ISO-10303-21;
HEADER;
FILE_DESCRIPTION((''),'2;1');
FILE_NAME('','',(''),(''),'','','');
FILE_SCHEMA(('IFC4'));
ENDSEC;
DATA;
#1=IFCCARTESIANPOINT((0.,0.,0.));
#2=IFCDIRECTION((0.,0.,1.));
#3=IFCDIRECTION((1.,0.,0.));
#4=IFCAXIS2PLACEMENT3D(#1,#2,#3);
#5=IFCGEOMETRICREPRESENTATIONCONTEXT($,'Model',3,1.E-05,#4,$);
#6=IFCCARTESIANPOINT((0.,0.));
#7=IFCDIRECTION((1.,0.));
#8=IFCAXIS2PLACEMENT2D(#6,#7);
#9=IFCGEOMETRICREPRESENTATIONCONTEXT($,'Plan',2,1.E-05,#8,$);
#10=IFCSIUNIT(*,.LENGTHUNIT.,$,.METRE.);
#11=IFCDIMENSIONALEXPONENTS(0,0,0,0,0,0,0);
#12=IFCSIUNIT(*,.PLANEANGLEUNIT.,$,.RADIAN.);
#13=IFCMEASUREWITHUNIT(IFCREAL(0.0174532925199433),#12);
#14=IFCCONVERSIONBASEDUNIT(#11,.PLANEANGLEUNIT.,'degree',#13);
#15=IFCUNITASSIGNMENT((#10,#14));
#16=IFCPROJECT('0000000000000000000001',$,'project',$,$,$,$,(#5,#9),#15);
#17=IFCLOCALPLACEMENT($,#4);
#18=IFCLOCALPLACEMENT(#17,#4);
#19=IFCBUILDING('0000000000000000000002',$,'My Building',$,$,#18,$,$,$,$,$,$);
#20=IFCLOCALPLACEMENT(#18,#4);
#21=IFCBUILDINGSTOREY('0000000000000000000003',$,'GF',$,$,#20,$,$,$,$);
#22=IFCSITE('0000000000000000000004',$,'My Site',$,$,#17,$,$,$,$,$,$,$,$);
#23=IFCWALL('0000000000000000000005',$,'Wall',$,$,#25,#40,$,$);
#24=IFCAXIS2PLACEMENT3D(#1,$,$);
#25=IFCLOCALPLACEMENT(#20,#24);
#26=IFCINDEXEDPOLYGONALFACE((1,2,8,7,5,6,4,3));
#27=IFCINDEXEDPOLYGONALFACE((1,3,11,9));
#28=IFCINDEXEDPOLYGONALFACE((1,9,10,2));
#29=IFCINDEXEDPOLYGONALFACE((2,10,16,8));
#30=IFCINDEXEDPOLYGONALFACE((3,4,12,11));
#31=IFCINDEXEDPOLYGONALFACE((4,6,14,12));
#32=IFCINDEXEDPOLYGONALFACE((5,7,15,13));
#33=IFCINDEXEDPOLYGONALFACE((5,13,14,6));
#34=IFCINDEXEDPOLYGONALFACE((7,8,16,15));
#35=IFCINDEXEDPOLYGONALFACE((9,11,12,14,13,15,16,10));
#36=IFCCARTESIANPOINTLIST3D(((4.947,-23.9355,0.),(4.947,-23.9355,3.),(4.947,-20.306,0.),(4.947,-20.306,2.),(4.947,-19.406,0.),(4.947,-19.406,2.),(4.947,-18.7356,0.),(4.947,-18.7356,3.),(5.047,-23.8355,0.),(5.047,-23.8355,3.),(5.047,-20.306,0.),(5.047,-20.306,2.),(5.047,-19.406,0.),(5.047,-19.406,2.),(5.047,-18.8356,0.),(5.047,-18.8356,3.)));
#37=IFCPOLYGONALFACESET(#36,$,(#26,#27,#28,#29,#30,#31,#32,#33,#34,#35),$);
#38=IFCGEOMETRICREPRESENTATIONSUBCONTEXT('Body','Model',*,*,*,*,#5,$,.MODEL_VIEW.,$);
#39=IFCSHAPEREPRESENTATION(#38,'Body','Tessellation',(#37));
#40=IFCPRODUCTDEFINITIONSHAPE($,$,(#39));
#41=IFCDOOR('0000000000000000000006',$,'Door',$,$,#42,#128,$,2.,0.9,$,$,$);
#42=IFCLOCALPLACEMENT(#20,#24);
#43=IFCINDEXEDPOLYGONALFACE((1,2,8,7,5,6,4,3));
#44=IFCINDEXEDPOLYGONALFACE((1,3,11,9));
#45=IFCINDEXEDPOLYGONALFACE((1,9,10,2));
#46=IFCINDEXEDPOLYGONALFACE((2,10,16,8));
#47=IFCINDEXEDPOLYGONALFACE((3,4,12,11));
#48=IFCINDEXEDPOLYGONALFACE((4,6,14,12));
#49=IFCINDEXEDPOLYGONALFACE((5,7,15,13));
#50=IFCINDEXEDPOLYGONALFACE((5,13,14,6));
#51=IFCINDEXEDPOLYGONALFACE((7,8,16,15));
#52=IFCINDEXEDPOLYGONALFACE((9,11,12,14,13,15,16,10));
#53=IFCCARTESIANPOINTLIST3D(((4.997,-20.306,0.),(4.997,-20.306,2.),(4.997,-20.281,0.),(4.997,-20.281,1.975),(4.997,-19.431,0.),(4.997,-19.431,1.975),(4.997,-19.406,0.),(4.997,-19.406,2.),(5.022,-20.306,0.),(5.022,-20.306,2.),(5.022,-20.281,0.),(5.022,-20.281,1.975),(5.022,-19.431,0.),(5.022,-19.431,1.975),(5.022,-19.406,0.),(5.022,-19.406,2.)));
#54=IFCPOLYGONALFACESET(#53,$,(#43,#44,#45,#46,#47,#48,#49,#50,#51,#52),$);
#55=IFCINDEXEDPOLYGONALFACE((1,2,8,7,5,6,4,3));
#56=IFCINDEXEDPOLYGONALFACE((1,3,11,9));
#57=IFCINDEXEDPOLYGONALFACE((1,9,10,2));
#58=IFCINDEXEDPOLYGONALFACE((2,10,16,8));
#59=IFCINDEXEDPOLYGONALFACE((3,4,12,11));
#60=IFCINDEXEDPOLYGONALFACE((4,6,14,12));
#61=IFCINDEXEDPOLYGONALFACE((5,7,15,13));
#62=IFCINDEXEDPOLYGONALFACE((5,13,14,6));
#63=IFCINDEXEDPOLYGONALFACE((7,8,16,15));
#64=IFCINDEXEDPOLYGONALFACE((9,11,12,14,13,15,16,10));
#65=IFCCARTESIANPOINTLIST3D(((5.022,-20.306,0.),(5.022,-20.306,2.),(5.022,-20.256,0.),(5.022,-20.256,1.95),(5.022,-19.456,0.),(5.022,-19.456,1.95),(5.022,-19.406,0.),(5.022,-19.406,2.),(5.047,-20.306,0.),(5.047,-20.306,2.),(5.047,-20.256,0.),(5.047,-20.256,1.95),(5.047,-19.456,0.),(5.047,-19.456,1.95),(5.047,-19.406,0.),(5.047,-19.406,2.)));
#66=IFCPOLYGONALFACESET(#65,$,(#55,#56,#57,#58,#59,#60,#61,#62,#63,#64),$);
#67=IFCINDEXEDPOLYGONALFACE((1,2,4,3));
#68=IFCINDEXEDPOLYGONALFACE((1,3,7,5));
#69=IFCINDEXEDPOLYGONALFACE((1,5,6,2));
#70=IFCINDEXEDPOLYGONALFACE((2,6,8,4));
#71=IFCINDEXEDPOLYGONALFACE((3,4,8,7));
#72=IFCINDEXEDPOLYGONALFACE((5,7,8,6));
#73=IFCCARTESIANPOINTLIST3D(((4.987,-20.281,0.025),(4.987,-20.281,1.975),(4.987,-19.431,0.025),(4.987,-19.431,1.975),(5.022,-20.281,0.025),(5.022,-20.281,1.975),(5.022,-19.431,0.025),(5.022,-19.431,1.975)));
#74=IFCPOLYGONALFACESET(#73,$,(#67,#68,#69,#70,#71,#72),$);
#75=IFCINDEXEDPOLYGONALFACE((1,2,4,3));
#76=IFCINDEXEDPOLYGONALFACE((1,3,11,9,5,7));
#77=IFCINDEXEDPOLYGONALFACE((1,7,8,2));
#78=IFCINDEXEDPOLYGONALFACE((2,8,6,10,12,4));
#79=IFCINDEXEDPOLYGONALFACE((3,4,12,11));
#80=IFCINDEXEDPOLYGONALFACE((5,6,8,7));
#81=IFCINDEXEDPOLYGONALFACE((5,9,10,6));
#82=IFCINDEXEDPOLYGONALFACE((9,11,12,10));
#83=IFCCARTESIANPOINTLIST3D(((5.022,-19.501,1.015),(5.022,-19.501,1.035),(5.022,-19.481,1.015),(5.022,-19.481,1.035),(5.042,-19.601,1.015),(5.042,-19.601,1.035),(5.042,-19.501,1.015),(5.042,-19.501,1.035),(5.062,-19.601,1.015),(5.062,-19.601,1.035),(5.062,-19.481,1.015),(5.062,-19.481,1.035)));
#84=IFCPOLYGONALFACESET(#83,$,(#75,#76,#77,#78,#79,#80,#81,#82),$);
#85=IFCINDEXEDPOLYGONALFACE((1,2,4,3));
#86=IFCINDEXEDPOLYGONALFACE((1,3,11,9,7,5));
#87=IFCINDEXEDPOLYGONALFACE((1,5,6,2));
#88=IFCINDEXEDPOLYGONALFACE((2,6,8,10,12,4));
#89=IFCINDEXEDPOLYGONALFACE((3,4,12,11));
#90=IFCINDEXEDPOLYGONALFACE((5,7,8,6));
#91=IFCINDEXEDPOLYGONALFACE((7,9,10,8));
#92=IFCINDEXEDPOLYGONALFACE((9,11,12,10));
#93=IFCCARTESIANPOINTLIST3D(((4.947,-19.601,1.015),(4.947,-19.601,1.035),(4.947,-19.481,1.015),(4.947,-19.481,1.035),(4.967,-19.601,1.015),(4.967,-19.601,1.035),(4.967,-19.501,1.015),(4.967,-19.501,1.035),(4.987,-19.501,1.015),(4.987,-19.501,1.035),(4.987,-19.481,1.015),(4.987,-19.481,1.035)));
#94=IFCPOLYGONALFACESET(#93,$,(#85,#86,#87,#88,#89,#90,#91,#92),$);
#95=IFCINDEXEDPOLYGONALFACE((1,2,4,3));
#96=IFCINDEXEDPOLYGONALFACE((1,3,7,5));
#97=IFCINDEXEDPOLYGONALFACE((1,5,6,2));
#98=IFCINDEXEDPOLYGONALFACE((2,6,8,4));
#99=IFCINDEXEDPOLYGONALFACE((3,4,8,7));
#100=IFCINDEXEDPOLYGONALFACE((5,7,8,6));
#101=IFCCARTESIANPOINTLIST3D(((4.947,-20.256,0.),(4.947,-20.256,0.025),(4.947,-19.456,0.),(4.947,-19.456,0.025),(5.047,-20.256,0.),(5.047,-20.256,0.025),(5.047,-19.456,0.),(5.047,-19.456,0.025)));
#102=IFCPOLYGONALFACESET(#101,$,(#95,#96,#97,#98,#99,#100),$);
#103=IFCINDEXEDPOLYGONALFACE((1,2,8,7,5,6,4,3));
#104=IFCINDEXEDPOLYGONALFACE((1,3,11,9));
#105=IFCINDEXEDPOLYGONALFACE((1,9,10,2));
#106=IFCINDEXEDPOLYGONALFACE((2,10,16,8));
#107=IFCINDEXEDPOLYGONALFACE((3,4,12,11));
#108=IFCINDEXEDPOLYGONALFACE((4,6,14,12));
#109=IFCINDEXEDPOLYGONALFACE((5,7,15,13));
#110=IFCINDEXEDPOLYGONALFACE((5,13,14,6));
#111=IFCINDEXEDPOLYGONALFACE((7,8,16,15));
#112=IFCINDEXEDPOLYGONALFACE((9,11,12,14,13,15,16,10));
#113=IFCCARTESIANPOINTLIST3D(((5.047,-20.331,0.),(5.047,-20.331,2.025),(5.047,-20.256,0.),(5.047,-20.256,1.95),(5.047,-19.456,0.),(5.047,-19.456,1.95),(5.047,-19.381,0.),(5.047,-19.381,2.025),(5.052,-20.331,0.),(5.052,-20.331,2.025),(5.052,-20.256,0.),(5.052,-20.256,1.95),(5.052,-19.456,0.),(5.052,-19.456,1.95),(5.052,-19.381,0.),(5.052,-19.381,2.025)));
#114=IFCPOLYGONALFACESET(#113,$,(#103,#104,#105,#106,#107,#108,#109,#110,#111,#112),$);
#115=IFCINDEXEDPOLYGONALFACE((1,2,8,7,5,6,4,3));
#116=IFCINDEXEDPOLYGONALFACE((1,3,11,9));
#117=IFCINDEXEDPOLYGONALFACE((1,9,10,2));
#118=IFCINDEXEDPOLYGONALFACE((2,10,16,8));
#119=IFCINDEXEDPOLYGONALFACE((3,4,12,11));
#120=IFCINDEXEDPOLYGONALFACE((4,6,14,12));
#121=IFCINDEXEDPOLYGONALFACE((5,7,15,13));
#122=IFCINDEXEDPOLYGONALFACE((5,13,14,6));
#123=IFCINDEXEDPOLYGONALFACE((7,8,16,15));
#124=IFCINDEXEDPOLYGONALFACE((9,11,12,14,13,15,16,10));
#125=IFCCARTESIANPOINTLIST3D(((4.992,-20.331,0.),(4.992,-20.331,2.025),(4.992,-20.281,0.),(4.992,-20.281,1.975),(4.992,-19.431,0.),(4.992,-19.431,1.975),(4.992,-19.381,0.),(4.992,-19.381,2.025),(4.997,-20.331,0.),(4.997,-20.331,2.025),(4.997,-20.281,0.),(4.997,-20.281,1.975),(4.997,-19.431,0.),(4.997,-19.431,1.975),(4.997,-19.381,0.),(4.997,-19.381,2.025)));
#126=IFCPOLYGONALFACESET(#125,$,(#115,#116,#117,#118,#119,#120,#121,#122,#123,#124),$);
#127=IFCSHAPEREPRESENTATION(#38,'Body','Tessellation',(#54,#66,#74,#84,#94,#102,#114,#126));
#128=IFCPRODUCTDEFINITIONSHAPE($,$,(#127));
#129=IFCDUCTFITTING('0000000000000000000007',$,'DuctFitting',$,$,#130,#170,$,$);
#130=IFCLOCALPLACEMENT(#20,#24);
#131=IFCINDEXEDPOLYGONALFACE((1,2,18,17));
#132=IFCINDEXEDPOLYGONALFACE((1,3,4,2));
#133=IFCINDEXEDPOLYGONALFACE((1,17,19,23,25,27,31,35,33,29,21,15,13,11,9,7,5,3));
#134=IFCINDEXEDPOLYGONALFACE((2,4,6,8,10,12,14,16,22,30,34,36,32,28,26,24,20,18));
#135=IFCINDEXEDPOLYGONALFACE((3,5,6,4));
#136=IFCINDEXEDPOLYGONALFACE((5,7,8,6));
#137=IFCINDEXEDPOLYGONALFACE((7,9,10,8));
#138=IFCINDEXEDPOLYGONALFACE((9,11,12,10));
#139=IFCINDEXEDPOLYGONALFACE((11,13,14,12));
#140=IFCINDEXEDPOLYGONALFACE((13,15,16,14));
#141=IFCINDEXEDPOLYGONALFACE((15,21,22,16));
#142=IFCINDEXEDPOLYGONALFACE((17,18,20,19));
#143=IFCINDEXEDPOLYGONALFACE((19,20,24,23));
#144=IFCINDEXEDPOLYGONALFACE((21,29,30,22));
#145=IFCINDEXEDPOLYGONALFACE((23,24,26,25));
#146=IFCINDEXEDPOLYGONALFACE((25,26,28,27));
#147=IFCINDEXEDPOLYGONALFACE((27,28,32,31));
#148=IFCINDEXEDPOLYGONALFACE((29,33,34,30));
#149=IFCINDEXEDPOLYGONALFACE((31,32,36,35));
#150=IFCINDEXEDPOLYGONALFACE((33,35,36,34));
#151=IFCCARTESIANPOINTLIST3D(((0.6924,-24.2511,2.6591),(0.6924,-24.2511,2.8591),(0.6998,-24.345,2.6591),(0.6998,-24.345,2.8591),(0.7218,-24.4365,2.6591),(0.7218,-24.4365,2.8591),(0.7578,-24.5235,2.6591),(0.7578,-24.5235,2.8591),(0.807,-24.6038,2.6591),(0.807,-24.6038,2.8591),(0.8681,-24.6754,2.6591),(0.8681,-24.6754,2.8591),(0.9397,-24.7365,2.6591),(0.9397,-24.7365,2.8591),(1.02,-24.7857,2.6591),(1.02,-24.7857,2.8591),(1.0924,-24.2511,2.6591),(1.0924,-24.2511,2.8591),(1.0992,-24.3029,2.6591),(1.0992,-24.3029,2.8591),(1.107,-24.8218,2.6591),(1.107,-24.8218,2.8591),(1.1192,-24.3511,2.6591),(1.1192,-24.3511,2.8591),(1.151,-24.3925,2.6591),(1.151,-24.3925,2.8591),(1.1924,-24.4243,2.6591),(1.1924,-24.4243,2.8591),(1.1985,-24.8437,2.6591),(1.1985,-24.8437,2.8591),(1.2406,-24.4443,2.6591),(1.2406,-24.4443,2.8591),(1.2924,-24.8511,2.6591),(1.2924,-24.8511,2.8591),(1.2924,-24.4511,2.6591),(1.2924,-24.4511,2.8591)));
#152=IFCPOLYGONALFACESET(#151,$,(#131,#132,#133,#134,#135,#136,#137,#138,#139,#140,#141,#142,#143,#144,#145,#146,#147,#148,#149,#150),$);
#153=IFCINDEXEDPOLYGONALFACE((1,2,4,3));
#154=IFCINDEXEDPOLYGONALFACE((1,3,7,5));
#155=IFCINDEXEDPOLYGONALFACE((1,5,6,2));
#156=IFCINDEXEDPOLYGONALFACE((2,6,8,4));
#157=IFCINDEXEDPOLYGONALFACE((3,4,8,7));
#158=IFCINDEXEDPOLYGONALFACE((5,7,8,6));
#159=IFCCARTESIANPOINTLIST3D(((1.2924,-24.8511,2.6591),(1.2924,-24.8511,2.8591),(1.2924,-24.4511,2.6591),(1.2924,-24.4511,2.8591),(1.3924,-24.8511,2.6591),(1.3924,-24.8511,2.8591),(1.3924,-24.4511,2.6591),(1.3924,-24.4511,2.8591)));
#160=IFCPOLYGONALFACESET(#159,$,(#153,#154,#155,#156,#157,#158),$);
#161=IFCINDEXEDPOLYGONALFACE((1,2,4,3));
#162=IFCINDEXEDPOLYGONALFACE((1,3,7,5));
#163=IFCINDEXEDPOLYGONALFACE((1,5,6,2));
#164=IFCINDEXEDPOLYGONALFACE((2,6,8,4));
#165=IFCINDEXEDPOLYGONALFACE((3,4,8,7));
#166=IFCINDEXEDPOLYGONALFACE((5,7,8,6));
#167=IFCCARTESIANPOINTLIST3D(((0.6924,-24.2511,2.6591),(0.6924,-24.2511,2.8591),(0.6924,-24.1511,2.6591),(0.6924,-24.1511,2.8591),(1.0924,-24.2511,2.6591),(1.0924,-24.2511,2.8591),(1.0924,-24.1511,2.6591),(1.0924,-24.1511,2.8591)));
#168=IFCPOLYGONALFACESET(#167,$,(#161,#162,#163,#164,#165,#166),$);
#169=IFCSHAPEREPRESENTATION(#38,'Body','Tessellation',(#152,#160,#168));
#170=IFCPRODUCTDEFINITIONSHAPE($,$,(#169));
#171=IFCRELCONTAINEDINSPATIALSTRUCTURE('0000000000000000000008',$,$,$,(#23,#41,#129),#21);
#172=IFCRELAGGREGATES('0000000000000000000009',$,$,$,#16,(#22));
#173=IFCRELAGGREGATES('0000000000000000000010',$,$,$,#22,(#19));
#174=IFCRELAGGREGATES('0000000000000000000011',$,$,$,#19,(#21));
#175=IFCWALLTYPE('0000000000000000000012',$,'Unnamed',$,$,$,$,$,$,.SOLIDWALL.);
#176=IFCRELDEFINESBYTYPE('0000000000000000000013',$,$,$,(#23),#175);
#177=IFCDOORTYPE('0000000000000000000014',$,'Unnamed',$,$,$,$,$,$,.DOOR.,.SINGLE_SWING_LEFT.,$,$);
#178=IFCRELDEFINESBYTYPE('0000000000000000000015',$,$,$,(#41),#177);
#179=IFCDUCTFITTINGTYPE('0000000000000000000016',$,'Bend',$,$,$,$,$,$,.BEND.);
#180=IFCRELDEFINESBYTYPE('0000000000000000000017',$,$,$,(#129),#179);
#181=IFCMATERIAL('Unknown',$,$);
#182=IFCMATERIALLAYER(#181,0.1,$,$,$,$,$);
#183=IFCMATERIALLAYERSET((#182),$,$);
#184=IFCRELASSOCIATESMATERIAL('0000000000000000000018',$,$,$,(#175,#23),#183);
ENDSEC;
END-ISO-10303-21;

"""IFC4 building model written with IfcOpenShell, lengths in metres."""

from ifc_helpers import new_model, entity, si_unit, converted_unit, frame, origin_with_axes, origin_2d_with_axis, place, context, subcontext, project, spatial, line, arc, indexed_curve, rectangle, outline, extrude, shape, source, transform, mapped, material, layer, layer_set, layer_usage, type_object, type_shapes, element, fill, save


model = new_model("IFC4")

# Units and contexts
model_context = context("Model", 3, precision=1e-05, world=origin_with_axes())
plan_context = context("Plan", 2, precision=1e-05, world=origin_2d_with_axis())
body_context_1 = subcontext(model_context, "Body", "Model", "MODEL_VIEW")
body_context_2 = subcontext(plan_context, "Body", "Plan", "PLAN_VIEW")
ifc_project = project(units=[si_unit("LENGTHUNIT", "METRE"), converted_unit("PLANEANGLEUNIT", "degree", entity("IfcReal", 0.0174532925199433), si_unit("PLANEANGLEUNIT", "RADIAN"), dimensions=[0, 0, 0, 0, 0, 0, 0])], contexts=[model_context, plan_context])

# Site, building, storey
site_placement = place(None, origin_with_axes())
site = spatial("IfcSite", under=ifc_project, at=site_placement, Name="My Site")
building_placement = place(site_placement, origin_with_axes())
building = spatial("IfcBuilding", under=site, at=building_placement, Name="My Building")
storey_placement = place(building_placement, origin_with_axes())
storey = spatial("IfcBuildingStorey", under=building, at=storey_placement, Name="GF")

# Shared definitions
ifc_material = material(Name="Unknown")

# Shared definitions
ifc_layer_1 = layer(ifc_material, 0.1)
ifc_layer_set_1 = layer_set([ifc_layer_1])
wall_type = type_object("IfcWallType", Name="Unnamed", PredefinedType="SOLIDWALL", material=ifc_layer_set_1)

# Shared definitions
shared_shape_1 = source(origin_with_axes(), body_context_1, "Body", "SweptSolid", [
    extrude(outline(indexed_curve([(0.0, 0.0), (0.9, 0.0), (0.9, 2.0), (0.0, 2.0)], segments=[line(1, 2, 3, 4, 1)])), frame((0.0, -0.6, 0.0), z_axis=(0.0, -1.0, 0.0), x_axis=(1.0, 0.0, 0.0)), (0.0, 0.0, -1.0), 1.2),
])
door_type = type_object("IfcDoorType", Name="Unnamed", OperationType="SINGLE_SWING_LEFT", PredefinedType="DOOR")
shared_shape_2 = source(origin_with_axes(), body_context_1, "Body", "SweptSolid", [
    extrude(outline(indexed_curve([(0.0, 0.0), (0.0, 2.0), (0.9, 2.0), (0.9, 0.0), (0.875, 0.0), (0.875, 1.975), (0.025, 1.975), (0.025, 0.0)], segments=[line(1, 2, 3, 4, 5, 6, 7, 8, 1)])), frame((0.0, 0.025, 0.0), z_axis=(0.0, -1.0, 0.0), x_axis=(1.0, 0.0, 0.0)), (0.0, 0.0, -1.0), 0.025),
    extrude(outline(indexed_curve([(0.0, 0.0), (0.0, 2.0), (0.9, 2.0), (0.9, 0.0), (0.85, 0.0), (0.85, 1.95), (0.05, 1.95), (0.05, 0.0)], segments=[line(1, 2, 3, 4, 5, 6, 7, 8, 1)])), frame((0.0, 0.0, 0.0), z_axis=(0.0, -1.0, 0.0), x_axis=(1.0, 0.0, 0.0)), (0.0, 0.0, -1.0), 0.025),
    extrude(outline(indexed_curve([(0.0, 0.0), (0.85, 0.0), (0.85, 0.035), (0.0, 0.035)], segments=[line(1, 2, 3, 4, 1)])), frame((0.025, 0.025, 0.025), z_axis=(0.0, 0.0, 1.0), x_axis=(1.0, 0.0, 0.0)), (0.0, 0.0, 1.0), 1.95),
    extrude(outline(indexed_curve([(0.0, 0.0), (0.0, -0.04), (-0.12, -0.04), (-0.12, -0.02), (-0.02, -0.02), (-0.02, 0.0)], segments=[line(1, 2, 3, 4, 5, 6, 1)])), frame((0.825, 0.025, 1.015), z_axis=(0.0, 0.0, 1.0), x_axis=(1.0, 0.0, 0.0)), (0.0, 0.0, 1.0), 0.02),
    extrude(outline(indexed_curve([(0.0, 0.0), (0.0, 0.04), (-0.12, 0.04), (-0.12, 0.02), (-0.02, 0.02), (-0.02, 0.0)], segments=[line(1, 2, 3, 4, 5, 6, 1)])), frame((0.825, 0.06, 1.015), z_axis=(0.0, 0.0, 1.0), x_axis=(1.0, 0.0, 0.0)), (0.0, 0.0, 1.0), 0.02),
    extrude(outline(indexed_curve([(0.0, 0.0), (0.8, 0.0), (0.8, 0.1), (0.0, 0.1)], segments=[line(1, 2, 3, 4, 1)])), frame((0.05, 0.0, 0.0), z_axis=(0.0, 0.0, 1.0), x_axis=(1.0, 0.0, 0.0)), (0.0, 0.0, 1.0), 0.025),
    extrude(outline(indexed_curve([(0.0, 0.0), (0.0, 2.025), (0.95, 2.025), (0.95, 0.0), (0.875, 0.0), (0.875, 1.95), (0.075, 1.95), (0.075, 0.0)], segments=[line(1, 2, 3, 4, 5, 6, 7, 8, 1)])), frame((-0.025, -0.005, 0.0), z_axis=(0.0, -1.0, 0.0), x_axis=(1.0, 0.0, 0.0)), (0.0, 0.0, -1.0), 0.005),
    extrude(outline(indexed_curve([(0.0, 0.0), (0.0, 2.025), (0.95, 2.025), (0.95, 0.0), (0.9, 0.0), (0.9, 1.975), (0.05, 1.975), (0.05, 0.0)], segments=[line(1, 2, 3, 4, 5, 6, 7, 8, 1)])), frame((-0.025, 0.05, 0.0), z_axis=(0.0, -1.0, 0.0), x_axis=(1.0, 0.0, 0.0)), (0.0, 0.0, -1.0), 0.005),
])
shared_shape_3 = source(origin_with_axes(), body_context_2, "Body", "Curve2D", [
    entity("IfcIndexedPolyCurve", entity("IfcCartesianPointList2D", [[0.0, 0.0], [0.0, 0.05], [0.025, 0.05], [0.025, 0.025], [0.05, 0.025], [0.05, 0.0]]), [entity("IfcLineIndex", [1, 2, 3, 4, 5, 6, 1])]),
    entity("IfcIndexedPolyCurve", entity("IfcCartesianPointList2D", [[0.9, 0.0], [0.9, 0.05], [0.875, 0.05], [0.875, 0.025], [0.85, 0.025], [0.85, 0.0]]), [entity("IfcLineIndex", [1, 2, 3, 4, 5, 6, 1])]),
    entity("IfcTrimmedCurve", entity("IfcEllipse", entity("IfcAxis2Placement2D", entity("IfcCartesianPoint", [0.06, 0.05]), entity("IfcDirection", [1.0, 0.0])), 0.815, 0.85), [entity("IfcCartesianPoint", [0.875, 0.05])], [entity("IfcCartesianPoint", [0.06, 0.9])], True, "CARTESIAN"),
    entity("IfcIndexedPolyCurve", entity("IfcCartesianPointList2D", [[0.025, 0.05], [0.06, 0.05], [0.06, 0.9], [0.025, 0.9]]), [entity("IfcLineIndex", [1, 2, 3, 4, 1])]),
])
type_shapes(door_type, [shared_shape_2, shared_shape_3])

# Wall, opening, door
ifc_layer_usage_1 = layer_usage(ifc_layer_set_1, "AXIS2", "POSITIVE", 0.0)
wall_1_placement = place(storey_placement, frame((5.047, -23.8355, 0.0), z_axis=(0.0, 0.0, 1.0), x_axis=(0.0, 1.0, 0.0)))
wall_1 = element("IfcWall", 1, at=wall_1_placement, inside=storey, type_object=wall_type, material=ifc_layer_usage_1, Name="Wall", context=body_context_1, shape_type="SweptSolid", body=[
    extrude(outline(indexed_curve([(0.0, 0.0), (-0.1, 0.1), (5.1, 0.1), (5.0, 0.0)], segments=[line(1, 2, 3, 4, 1)])), origin_with_axes(), (0.0, 0.0, 1.0), 3.0),
])
opening_1_placement = place(wall_1_placement, frame((3.5295, 0.0, 0.0), z_axis=(0.0, 0.0, 1.0), x_axis=(1.0, 0.0, 0.0)))
opening_1 = element("IfcOpeningElement", 2, at=opening_1_placement, cuts=wall_1, PredefinedType="OPENING", context=body_context_1, shape_type="MappedRepresentation", body=[
    mapped(shared_shape_1, transform((0.0, 0.0, 0.0), x_axis=(1.0, 0.0, 0.0), y_axis=(0.0, 1.0, 0.0), z_axis=(0.0, 0.0, 1.0), scale=1.0)),
])
door_1_placement = place(opening_1_placement, frame((0.0, 0.0, 0.0), z_axis=(0.0, 0.0, 1.0), x_axis=(1.0, 0.0, 0.0)))
door_1 = element("IfcDoor", 3, at=door_1_placement, inside=storey, type_object=door_type, Name="Door", OverallHeight=2.0, OverallWidth=0.9, shapes=[
    shape(body_context_1, "Body", "MappedRepresentation", [mapped(shared_shape_2, transform((0.0, 0.0, 0.0), x_axis=(1.0, 0.0, 0.0), y_axis=(0.0, 1.0, 0.0), z_axis=(0.0, 0.0, 1.0), scale=1.0))]),
    shape(body_context_2, "Body", "MappedRepresentation", [mapped(shared_shape_3, transform((0.0, 0.0, 0.0), x_axis=(1.0, 0.0, 0.0), y_axis=(0.0, 1.0, 0.0), z_axis=(0.0, 0.0, 1.0), scale=1.0))]),
])
fill(opening_1, door_1)

# Duct fitting
duct_fitting_type = type_object("IfcDuctFittingType", Name="Bend", PredefinedType="BEND")
shared_shape_4 = source(origin_with_axes(), body_context_1, "Body", "SweptSolid", [
    extrude(outline(indexed_curve([(-0.2, 0.0), (-0.2586, -0.1414), (-0.4, -0.2), (-0.4, -0.6), (0.0243, -0.4243), (0.2, 0.0)], segments=[arc(1, 2, 3), line(3, 4), arc(4, 5, 6), line(6, 1)])), frame((0.0, -0.1, -0.1), z_axis=(0.0, -1.0, 0.0), x_axis=(1.0, 0.0, 0.0)), (0.0, 0.0, -1.0), 0.2),
    extrude(rectangle(XDim=0.4, YDim=0.2), origin_with_axes(), (0.0, 0.0, -1.0), 0.1),
    extrude(rectangle(XDim=0.4, YDim=0.2), frame((-0.4, 0.0, -0.5), z_axis=(-1.0, 0.0, 0.0), x_axis=(0.0, 0.0, -1.0)), (0.0, 0.0, 1.0), 0.1),
])
type_shapes(duct_fitting_type, [shared_shape_4])
for number, where, z_axis, x_axis, name in (
    (4, (1.3924, -24.6511, 2.7591), (1.0, 0.0, 0.0), (0.0, -1.0, 0.0), "DuctFitting"),
):
    element("IfcDuctFitting", number, at=place(storey_placement, frame(where, z_axis=z_axis, x_axis=x_axis)), inside=storey, type_object=duct_fitting_type, Name=name, context=body_context_1, shape_type="MappedRepresentation", body=[
        mapped(shared_shape_4, transform((0.0, 0.0, 0.0), x_axis=(1.0, 0.0, 0.0), y_axis=(0.0, 1.0, 0.0), z_axis=(0.0, 0.0, 1.0), scale=1.0)),
    ])

save(model, "model.ifc")
